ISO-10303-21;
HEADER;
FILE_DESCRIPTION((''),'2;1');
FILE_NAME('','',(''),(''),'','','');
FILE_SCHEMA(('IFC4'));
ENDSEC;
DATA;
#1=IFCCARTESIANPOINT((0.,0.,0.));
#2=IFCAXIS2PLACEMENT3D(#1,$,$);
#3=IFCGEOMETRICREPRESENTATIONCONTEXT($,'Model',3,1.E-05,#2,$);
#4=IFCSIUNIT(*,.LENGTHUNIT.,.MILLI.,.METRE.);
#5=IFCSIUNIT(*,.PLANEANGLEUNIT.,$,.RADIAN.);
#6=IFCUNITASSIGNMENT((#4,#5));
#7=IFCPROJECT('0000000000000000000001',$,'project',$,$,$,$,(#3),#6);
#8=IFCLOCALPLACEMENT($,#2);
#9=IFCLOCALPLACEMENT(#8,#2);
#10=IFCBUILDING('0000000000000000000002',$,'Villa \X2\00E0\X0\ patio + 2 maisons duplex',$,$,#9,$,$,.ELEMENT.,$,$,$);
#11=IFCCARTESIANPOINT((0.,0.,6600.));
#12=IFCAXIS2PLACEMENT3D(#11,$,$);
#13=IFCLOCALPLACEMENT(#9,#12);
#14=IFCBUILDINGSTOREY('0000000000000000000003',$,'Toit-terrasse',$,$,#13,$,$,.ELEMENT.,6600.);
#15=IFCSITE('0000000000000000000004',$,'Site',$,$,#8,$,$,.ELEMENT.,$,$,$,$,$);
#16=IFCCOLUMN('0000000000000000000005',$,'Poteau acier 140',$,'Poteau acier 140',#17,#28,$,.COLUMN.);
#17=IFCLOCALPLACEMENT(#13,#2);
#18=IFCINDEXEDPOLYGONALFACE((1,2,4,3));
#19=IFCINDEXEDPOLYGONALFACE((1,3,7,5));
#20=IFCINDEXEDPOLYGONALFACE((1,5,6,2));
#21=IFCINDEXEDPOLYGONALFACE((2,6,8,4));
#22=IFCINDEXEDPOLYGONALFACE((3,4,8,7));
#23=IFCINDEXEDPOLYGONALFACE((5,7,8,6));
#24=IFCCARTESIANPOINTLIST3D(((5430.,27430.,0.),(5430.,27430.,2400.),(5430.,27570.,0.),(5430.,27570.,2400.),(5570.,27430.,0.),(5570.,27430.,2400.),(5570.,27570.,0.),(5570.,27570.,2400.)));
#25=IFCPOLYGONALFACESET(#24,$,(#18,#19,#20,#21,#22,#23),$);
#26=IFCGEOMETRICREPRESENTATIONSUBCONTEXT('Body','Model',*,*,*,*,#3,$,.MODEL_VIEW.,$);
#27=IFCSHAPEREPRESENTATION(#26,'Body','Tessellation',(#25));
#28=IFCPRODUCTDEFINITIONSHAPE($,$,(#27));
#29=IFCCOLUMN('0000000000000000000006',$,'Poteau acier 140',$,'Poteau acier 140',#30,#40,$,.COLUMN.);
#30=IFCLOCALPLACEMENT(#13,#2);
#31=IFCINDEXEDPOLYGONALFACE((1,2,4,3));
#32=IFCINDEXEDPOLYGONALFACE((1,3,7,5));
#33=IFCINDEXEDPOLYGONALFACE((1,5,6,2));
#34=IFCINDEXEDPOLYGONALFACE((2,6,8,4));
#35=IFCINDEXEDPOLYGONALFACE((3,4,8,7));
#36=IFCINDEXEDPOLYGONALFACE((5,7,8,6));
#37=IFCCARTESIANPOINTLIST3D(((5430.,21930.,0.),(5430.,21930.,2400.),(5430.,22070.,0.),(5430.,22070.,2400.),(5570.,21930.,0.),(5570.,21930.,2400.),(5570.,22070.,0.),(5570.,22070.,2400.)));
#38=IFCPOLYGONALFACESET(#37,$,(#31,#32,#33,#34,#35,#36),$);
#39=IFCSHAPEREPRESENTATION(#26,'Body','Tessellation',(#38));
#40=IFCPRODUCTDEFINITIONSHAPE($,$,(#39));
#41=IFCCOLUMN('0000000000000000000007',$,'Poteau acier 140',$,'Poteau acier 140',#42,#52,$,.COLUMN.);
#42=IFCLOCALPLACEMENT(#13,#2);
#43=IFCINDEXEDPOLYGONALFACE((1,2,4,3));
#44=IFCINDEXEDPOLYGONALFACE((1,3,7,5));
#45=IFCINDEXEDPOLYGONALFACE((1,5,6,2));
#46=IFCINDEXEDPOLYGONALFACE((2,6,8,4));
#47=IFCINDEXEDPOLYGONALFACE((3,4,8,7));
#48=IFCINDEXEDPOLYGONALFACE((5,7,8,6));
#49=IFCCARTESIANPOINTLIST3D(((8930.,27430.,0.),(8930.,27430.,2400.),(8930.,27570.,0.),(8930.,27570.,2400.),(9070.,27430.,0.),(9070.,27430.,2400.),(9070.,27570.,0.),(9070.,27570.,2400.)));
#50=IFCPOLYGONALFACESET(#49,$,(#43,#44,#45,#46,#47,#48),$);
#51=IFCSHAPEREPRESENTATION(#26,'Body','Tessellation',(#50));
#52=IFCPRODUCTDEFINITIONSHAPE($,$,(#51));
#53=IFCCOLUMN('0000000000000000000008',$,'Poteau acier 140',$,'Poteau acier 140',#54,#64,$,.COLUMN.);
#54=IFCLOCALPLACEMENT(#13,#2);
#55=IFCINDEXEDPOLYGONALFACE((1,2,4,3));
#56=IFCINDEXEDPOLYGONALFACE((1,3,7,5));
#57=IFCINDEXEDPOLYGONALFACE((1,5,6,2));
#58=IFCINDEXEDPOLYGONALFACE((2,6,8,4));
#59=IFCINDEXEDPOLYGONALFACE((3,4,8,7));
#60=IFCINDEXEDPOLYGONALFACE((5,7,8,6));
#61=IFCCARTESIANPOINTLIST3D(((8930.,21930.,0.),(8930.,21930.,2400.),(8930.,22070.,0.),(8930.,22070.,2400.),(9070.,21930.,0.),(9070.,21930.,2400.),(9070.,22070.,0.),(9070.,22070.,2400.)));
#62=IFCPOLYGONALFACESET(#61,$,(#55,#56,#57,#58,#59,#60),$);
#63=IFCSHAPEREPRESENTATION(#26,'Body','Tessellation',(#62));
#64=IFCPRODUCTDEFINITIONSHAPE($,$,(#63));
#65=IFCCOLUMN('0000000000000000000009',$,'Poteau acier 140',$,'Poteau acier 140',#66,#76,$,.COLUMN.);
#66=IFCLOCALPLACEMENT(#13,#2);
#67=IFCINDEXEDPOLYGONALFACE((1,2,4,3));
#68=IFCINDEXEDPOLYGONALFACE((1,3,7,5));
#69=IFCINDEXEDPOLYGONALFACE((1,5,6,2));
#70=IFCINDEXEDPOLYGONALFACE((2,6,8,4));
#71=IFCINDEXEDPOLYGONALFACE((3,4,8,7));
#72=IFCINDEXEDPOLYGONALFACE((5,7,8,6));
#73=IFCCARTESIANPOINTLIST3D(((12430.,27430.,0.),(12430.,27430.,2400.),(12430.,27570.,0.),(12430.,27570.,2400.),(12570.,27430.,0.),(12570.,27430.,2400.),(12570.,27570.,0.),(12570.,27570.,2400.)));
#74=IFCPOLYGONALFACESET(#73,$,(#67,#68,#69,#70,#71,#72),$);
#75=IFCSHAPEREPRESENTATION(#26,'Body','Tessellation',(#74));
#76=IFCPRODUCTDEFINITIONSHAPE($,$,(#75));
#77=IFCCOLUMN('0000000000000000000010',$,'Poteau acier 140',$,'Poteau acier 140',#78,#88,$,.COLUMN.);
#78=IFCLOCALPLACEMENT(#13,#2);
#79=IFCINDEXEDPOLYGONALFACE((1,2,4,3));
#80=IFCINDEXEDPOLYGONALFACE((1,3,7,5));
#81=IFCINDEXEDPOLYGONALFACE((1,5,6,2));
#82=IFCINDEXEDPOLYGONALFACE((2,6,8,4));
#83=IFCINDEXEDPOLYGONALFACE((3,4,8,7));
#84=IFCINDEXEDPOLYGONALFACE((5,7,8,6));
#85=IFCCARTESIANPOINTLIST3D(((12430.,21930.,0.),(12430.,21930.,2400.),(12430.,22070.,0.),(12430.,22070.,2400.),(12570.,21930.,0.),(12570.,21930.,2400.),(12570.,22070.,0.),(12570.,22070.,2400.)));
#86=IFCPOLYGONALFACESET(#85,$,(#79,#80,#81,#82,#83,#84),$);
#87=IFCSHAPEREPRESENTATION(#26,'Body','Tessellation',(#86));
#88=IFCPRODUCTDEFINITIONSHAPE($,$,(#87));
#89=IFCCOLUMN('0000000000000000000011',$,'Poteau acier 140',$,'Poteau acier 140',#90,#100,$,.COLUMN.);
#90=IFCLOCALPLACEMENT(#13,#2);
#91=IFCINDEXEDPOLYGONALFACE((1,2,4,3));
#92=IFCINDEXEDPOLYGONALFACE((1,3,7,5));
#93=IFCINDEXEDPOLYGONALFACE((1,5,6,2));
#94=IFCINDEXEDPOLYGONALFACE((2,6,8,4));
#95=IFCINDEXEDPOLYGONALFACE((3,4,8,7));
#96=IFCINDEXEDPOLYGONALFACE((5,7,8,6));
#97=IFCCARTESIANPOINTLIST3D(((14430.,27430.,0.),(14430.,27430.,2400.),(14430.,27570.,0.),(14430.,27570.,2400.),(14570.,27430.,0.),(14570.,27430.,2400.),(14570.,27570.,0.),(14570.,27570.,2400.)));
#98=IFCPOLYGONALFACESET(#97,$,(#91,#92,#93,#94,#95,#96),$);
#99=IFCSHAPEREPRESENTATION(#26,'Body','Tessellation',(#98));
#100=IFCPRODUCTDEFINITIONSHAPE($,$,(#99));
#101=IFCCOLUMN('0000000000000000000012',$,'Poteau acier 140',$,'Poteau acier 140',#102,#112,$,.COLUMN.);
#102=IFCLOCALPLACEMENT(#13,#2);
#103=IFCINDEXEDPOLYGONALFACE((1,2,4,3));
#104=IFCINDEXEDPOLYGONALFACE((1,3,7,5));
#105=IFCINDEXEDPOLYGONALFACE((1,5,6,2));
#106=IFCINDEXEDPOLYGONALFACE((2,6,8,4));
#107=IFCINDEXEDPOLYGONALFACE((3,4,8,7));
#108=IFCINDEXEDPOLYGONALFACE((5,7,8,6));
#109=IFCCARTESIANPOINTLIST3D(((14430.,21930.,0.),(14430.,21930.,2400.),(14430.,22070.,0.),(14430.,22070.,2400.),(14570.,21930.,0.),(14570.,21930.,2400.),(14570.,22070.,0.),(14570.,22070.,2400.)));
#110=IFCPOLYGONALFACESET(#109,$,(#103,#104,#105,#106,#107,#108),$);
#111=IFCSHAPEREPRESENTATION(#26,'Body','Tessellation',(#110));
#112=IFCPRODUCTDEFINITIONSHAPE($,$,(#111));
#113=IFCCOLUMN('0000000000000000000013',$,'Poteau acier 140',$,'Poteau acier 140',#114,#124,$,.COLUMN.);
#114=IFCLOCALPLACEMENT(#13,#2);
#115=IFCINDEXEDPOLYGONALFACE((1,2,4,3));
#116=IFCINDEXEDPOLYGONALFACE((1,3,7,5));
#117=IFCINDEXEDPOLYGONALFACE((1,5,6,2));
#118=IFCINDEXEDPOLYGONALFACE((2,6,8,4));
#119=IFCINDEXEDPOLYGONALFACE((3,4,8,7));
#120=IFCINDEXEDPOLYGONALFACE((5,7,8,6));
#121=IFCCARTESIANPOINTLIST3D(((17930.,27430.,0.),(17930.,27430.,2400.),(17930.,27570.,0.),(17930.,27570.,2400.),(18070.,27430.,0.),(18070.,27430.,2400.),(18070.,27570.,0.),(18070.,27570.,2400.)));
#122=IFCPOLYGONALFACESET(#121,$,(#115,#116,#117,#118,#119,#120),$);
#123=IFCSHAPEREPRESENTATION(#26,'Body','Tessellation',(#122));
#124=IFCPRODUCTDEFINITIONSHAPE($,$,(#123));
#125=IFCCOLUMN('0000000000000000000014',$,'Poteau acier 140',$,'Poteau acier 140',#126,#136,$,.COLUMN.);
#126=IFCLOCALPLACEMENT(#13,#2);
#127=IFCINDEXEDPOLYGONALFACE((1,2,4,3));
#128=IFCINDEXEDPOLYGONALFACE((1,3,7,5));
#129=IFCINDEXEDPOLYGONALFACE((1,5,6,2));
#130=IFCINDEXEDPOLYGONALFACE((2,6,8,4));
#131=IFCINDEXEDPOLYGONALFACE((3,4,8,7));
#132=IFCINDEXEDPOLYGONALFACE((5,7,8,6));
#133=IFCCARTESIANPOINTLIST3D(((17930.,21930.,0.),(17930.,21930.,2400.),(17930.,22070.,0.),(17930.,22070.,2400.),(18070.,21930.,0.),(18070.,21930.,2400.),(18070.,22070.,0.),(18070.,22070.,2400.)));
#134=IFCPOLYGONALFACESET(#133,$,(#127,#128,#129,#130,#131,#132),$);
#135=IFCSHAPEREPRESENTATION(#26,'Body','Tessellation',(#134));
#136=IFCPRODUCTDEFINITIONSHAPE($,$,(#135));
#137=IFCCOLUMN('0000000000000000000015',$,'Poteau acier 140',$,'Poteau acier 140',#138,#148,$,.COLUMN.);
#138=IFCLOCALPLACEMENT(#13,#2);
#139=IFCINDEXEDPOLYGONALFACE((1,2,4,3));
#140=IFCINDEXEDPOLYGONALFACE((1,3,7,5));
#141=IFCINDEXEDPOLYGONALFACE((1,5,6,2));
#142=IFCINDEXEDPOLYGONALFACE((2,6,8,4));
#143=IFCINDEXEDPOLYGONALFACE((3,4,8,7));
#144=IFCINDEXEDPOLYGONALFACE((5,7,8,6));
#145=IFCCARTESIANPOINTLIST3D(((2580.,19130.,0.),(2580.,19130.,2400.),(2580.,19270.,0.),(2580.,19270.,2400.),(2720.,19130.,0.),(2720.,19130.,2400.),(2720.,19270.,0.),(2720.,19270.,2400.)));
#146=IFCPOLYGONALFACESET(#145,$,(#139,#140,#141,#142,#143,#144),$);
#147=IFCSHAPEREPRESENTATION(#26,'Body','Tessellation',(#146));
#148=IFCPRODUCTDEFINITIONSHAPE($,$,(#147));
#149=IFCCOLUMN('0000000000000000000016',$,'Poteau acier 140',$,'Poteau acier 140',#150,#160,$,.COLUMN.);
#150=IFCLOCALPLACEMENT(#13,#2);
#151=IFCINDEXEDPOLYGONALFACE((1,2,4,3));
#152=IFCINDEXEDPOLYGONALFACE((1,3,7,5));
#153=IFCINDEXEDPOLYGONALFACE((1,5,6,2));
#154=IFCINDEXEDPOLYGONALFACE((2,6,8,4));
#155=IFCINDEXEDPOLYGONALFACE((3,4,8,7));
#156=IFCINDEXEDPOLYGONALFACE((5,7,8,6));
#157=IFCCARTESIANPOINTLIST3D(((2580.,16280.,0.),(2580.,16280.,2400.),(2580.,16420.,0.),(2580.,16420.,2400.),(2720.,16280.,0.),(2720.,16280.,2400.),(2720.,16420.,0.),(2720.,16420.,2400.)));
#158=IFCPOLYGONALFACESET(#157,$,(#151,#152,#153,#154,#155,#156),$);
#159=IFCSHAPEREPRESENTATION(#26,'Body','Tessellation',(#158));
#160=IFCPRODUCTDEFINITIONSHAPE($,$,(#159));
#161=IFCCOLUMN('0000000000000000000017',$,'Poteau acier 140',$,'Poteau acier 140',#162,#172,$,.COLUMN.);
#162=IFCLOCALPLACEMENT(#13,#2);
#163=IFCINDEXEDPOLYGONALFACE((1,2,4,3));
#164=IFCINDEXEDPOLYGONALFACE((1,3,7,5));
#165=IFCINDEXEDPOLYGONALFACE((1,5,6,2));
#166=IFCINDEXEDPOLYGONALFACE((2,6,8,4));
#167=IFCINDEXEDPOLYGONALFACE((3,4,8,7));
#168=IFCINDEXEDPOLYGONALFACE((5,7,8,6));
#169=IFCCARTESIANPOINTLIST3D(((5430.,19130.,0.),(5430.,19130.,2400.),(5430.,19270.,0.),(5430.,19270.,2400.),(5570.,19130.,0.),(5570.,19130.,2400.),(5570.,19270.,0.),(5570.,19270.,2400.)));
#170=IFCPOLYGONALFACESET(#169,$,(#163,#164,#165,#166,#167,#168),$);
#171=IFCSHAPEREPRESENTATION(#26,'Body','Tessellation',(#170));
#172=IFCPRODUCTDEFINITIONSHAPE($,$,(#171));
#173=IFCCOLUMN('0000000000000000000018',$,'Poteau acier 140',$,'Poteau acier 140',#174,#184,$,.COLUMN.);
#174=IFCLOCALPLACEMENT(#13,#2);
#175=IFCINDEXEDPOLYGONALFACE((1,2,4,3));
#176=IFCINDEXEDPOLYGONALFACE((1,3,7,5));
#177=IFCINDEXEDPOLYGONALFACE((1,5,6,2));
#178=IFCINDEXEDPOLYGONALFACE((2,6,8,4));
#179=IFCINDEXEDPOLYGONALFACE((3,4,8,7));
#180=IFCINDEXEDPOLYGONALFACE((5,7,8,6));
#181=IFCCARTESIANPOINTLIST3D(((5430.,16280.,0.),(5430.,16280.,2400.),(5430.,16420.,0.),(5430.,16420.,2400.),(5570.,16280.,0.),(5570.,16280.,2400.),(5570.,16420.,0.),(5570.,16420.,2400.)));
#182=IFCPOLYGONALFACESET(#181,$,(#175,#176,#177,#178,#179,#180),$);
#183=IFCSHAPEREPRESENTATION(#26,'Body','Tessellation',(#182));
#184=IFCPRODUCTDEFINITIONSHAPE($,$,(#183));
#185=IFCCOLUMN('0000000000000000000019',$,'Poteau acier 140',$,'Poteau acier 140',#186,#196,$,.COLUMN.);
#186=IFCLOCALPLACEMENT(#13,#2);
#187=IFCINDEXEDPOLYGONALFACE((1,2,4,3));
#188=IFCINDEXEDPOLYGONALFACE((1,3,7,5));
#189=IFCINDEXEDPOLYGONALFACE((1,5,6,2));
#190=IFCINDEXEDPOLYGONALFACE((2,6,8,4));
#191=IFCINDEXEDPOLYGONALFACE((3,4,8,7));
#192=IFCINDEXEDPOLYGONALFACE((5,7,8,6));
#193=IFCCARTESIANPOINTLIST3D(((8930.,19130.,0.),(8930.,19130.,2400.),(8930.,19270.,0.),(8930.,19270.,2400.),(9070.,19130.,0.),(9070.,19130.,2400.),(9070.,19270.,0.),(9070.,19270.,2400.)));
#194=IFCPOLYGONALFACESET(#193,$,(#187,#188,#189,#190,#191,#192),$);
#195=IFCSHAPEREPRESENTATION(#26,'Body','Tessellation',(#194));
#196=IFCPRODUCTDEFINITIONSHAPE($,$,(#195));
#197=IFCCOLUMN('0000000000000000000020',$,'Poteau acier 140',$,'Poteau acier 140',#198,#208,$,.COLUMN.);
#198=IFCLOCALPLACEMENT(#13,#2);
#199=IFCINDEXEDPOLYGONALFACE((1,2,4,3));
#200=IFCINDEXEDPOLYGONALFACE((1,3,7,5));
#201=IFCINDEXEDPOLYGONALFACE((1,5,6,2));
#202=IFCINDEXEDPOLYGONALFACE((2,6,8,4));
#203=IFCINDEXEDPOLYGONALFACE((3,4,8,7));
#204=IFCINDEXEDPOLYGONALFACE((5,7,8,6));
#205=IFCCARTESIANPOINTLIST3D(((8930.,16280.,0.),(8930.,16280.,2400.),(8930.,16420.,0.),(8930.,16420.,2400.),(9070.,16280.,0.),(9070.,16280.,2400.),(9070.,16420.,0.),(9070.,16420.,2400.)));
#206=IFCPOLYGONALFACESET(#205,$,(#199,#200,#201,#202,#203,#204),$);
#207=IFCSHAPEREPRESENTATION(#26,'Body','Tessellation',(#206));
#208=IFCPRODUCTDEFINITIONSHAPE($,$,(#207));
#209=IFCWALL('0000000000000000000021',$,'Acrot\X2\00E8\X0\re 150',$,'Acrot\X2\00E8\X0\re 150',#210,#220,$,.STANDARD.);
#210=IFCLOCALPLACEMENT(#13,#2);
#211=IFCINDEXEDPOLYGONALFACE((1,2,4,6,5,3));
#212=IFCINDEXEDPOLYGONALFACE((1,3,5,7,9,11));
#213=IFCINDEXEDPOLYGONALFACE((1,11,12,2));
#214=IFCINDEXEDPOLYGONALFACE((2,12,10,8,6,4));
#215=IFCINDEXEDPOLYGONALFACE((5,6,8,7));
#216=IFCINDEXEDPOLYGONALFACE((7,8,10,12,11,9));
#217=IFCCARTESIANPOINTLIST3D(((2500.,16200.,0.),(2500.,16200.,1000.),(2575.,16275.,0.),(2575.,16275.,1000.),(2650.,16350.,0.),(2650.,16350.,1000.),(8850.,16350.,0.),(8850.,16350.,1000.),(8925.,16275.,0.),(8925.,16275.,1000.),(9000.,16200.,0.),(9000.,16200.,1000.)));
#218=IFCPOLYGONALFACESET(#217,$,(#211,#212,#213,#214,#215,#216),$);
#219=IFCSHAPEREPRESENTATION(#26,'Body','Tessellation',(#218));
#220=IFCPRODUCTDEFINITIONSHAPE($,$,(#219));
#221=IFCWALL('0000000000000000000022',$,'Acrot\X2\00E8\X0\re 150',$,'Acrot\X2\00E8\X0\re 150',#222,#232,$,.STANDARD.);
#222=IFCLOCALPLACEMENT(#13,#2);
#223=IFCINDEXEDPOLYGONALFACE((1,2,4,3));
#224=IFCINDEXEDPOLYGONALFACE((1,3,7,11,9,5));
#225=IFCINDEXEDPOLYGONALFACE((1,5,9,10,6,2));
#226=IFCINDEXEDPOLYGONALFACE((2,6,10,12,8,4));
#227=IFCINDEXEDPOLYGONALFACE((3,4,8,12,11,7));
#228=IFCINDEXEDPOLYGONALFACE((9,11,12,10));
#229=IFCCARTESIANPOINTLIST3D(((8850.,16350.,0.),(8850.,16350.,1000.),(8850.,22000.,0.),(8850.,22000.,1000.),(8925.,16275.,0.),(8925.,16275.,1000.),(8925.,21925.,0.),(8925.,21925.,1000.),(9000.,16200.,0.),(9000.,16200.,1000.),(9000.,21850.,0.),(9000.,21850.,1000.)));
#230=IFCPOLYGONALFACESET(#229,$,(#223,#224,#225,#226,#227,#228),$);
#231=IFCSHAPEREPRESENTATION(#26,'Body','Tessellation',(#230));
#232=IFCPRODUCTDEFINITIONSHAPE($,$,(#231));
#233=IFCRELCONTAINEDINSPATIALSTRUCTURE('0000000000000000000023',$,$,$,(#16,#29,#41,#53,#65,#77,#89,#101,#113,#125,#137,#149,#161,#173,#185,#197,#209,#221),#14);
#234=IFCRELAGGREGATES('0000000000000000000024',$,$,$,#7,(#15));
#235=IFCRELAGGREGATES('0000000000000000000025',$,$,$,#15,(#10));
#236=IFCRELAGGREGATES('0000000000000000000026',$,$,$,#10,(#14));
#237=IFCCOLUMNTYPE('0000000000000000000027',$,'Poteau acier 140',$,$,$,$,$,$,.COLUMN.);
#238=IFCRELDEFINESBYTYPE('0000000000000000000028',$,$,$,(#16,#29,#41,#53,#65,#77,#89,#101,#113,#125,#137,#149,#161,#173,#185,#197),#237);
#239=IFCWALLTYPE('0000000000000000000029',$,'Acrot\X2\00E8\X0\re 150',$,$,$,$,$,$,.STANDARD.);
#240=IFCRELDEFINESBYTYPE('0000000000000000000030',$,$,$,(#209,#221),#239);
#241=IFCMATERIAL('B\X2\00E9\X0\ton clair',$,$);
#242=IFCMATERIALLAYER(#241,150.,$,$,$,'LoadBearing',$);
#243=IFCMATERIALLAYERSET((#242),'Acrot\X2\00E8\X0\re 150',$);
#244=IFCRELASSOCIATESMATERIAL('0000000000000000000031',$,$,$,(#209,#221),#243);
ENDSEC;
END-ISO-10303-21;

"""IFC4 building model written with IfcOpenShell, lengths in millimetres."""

from ifc_helpers import new_model, si_unit, frame, origin, origin_2d, place, context, subcontext, project, spatial, polyline, rectangle, outline, extrude, material, layer, layer_set, layer_usage, material_profile, profile_set, profile_usage, type_object, element, save


model = new_model("IFC4")

# Units and contexts
model_context = context("Model", 3, precision=1e-05, world=origin())
body_context = subcontext(model_context, "Body", "Model", "MODEL_VIEW")
ifc_project = project(units=[si_unit("LENGTHUNIT", "METRE", prefix="MILLI"), si_unit("PLANEANGLEUNIT", "RADIAN")], contexts=[model_context])

# Site, building, storey
site_placement = place(None, origin())
site = spatial("IfcSite", under=ifc_project, at=site_placement, Name="Site", CompositionType="ELEMENT")
building_placement = place(site_placement, origin())
building = spatial("IfcBuilding", under=site, at=building_placement, Name="Villa à patio + 2 maisons duplex", CompositionType="ELEMENT")
storey_placement = place(building_placement, frame((0.0, 0.0, 6600.0)))
storey = spatial("IfcBuildingStorey", under=building, at=storey_placement, Name="Toit-terrasse", CompositionType="ELEMENT", Elevation=6600.0)

# Columns
ifc_material_profile = material_profile(None, rectangle(XDim=140.0, YDim=140.0, at=origin_2d()), Name="Poteau acier 140")
ifc_profile_set = profile_set([ifc_material_profile], Name="Poteau acier 140")
ifc_profile_usage = profile_usage(ifc_profile_set, cardinal=5)
column_type = type_object("IfcColumnType", Name="Poteau acier 140", PredefinedType="COLUMN", material=ifc_profile_set)
for number, where, z_axis, x_axis, name in (
    (1, (5500.0, 27500.0, 0.0), (0.0, 0.0, 1.0), (1.0, 0.0, 0.0), "Poteau acier 140"),
    (2, (5500.0, 22000.0, 0.0), (0.0, 0.0, 1.0), (1.0, 0.0, 0.0), "Poteau acier 140"),
    (3, (9000.0, 27500.0, 0.0), (0.0, 0.0, 1.0), (1.0, 0.0, 0.0), "Poteau acier 140"),
    (4, (9000.0, 22000.0, 0.0), (0.0, 0.0, 1.0), (1.0, 0.0, 0.0), "Poteau acier 140"),
    (5, (12500.0, 27500.0, 0.0), (0.0, 0.0, 1.0), (1.0, 0.0, 0.0), "Poteau acier 140"),
    (6, (12500.0, 22000.0, 0.0), (0.0, 0.0, 1.0), (1.0, 0.0, 0.0), "Poteau acier 140"),
    (7, (14500.0, 27500.0, 0.0), (0.0, 0.0, 1.0), (1.0, 0.0, 0.0), "Poteau acier 140"),
    (8, (14500.0, 22000.0, 0.0), (0.0, 0.0, 1.0), (1.0, 0.0, 0.0), "Poteau acier 140"),
    (9, (18000.0, 27500.0, 0.0), (0.0, 0.0, 1.0), (1.0, 0.0, 0.0), "Poteau acier 140"),
    (10, (18000.0, 22000.0, 0.0), (0.0, 0.0, 1.0), (1.0, 0.0, 0.0), "Poteau acier 140"),
    (11, (2650.0, 19200.0, 0.0), (0.0, 0.0, 1.0), (1.0, 0.0, 0.0), "Poteau acier 140"),
    (12, (2650.0, 16350.0, 0.0), (0.0, 0.0, 1.0), (1.0, 0.0, 0.0), "Poteau acier 140"),
    (13, (5500.0, 19200.0, 0.0), (0.0, 0.0, 1.0), (1.0, 0.0, 0.0), "Poteau acier 140"),
    (14, (5500.0, 16350.0, 0.0), (0.0, 0.0, 1.0), (1.0, 0.0, 0.0), "Poteau acier 140"),
    (15, (9000.0, 19200.0, 0.0), (0.0, 0.0, 1.0), (1.0, 0.0, 0.0), "Poteau acier 140"),
    (16, (9000.0, 16350.0, 0.0), (0.0, 0.0, 1.0), (1.0, 0.0, 0.0), "Poteau acier 140"),
):
    element("IfcColumn", number, at=place(storey_placement, frame(where, z_axis=z_axis, x_axis=x_axis)), inside=storey, type_object=column_type, material=ifc_profile_usage, Name=name, ObjectType="Poteau acier 140", PredefinedType="COLUMN", context=body_context, shape_type="SweptSolid", body=[
        extrude(rectangle(XDim=140.0, YDim=140.0, at=origin_2d()), origin(), (0.0, 0.0, 1.0), 2400.0),
    ])

# Walls
ifc_material_1 = material(Name="Béton clair")
ifc_layer_1 = layer(ifc_material_1, 150.0, Category="LoadBearing")
ifc_layer_set_1 = layer_set([ifc_layer_1], Name="Acrotère 150")
ifc_layer_usage_1 = layer_usage(ifc_layer_set_1, "AXIS2", "NEGATIVE", 75.0)
wall_type_1 = type_object("IfcWallType", Name="Acrotère 150", PredefinedType="STANDARD")
wall_1_placement = place(storey_placement, frame((2575.0, 16275.0, 0.0), z_axis=(0.0, 0.0, 1.0), x_axis=(1.0, 0.0, 0.0)))
element("IfcWall", 17, at=wall_1_placement, inside=storey, type_object=wall_type_1, material=ifc_layer_usage_1, Name="Acrotère 150", ObjectType="Acrotère 150", PredefinedType="STANDARD", context=body_context, shape_type="SweptSolid", body=[
    extrude(outline(polyline([(-75.0, -75.0), (0.0, 0.0), (75.0, 75.0), (6275.0, 75.0), (6350.0, 0.0), (6425.0, -75.0), (-75.0, -75.0)])), origin(), (0.0, 0.0, 1.0), 1000.0),
])
wall_2_placement = place(storey_placement, frame((8925.0, 16275.0, 0.0), z_axis=(0.0, 0.0, 1.0), x_axis=(0.0, 1.0, 0.0)))
element("IfcWall", 18, at=wall_2_placement, inside=storey, type_object=wall_type_1, material=ifc_layer_usage_1, Name="Acrotère 150", ObjectType="Acrotère 150", PredefinedType="STANDARD", context=body_context, shape_type="SweptSolid", body=[
    extrude(outline(polyline([(-75.0, -75.0), (0.0, 0.0), (75.0, 75.0), (5725.0, 75.0), (5650.0, 0.0), (5575.0, -75.0), (-75.0, -75.0)])), origin(), (0.0, 0.0, 1.0), 1000.0),
])

save(model, "model.ifc")
